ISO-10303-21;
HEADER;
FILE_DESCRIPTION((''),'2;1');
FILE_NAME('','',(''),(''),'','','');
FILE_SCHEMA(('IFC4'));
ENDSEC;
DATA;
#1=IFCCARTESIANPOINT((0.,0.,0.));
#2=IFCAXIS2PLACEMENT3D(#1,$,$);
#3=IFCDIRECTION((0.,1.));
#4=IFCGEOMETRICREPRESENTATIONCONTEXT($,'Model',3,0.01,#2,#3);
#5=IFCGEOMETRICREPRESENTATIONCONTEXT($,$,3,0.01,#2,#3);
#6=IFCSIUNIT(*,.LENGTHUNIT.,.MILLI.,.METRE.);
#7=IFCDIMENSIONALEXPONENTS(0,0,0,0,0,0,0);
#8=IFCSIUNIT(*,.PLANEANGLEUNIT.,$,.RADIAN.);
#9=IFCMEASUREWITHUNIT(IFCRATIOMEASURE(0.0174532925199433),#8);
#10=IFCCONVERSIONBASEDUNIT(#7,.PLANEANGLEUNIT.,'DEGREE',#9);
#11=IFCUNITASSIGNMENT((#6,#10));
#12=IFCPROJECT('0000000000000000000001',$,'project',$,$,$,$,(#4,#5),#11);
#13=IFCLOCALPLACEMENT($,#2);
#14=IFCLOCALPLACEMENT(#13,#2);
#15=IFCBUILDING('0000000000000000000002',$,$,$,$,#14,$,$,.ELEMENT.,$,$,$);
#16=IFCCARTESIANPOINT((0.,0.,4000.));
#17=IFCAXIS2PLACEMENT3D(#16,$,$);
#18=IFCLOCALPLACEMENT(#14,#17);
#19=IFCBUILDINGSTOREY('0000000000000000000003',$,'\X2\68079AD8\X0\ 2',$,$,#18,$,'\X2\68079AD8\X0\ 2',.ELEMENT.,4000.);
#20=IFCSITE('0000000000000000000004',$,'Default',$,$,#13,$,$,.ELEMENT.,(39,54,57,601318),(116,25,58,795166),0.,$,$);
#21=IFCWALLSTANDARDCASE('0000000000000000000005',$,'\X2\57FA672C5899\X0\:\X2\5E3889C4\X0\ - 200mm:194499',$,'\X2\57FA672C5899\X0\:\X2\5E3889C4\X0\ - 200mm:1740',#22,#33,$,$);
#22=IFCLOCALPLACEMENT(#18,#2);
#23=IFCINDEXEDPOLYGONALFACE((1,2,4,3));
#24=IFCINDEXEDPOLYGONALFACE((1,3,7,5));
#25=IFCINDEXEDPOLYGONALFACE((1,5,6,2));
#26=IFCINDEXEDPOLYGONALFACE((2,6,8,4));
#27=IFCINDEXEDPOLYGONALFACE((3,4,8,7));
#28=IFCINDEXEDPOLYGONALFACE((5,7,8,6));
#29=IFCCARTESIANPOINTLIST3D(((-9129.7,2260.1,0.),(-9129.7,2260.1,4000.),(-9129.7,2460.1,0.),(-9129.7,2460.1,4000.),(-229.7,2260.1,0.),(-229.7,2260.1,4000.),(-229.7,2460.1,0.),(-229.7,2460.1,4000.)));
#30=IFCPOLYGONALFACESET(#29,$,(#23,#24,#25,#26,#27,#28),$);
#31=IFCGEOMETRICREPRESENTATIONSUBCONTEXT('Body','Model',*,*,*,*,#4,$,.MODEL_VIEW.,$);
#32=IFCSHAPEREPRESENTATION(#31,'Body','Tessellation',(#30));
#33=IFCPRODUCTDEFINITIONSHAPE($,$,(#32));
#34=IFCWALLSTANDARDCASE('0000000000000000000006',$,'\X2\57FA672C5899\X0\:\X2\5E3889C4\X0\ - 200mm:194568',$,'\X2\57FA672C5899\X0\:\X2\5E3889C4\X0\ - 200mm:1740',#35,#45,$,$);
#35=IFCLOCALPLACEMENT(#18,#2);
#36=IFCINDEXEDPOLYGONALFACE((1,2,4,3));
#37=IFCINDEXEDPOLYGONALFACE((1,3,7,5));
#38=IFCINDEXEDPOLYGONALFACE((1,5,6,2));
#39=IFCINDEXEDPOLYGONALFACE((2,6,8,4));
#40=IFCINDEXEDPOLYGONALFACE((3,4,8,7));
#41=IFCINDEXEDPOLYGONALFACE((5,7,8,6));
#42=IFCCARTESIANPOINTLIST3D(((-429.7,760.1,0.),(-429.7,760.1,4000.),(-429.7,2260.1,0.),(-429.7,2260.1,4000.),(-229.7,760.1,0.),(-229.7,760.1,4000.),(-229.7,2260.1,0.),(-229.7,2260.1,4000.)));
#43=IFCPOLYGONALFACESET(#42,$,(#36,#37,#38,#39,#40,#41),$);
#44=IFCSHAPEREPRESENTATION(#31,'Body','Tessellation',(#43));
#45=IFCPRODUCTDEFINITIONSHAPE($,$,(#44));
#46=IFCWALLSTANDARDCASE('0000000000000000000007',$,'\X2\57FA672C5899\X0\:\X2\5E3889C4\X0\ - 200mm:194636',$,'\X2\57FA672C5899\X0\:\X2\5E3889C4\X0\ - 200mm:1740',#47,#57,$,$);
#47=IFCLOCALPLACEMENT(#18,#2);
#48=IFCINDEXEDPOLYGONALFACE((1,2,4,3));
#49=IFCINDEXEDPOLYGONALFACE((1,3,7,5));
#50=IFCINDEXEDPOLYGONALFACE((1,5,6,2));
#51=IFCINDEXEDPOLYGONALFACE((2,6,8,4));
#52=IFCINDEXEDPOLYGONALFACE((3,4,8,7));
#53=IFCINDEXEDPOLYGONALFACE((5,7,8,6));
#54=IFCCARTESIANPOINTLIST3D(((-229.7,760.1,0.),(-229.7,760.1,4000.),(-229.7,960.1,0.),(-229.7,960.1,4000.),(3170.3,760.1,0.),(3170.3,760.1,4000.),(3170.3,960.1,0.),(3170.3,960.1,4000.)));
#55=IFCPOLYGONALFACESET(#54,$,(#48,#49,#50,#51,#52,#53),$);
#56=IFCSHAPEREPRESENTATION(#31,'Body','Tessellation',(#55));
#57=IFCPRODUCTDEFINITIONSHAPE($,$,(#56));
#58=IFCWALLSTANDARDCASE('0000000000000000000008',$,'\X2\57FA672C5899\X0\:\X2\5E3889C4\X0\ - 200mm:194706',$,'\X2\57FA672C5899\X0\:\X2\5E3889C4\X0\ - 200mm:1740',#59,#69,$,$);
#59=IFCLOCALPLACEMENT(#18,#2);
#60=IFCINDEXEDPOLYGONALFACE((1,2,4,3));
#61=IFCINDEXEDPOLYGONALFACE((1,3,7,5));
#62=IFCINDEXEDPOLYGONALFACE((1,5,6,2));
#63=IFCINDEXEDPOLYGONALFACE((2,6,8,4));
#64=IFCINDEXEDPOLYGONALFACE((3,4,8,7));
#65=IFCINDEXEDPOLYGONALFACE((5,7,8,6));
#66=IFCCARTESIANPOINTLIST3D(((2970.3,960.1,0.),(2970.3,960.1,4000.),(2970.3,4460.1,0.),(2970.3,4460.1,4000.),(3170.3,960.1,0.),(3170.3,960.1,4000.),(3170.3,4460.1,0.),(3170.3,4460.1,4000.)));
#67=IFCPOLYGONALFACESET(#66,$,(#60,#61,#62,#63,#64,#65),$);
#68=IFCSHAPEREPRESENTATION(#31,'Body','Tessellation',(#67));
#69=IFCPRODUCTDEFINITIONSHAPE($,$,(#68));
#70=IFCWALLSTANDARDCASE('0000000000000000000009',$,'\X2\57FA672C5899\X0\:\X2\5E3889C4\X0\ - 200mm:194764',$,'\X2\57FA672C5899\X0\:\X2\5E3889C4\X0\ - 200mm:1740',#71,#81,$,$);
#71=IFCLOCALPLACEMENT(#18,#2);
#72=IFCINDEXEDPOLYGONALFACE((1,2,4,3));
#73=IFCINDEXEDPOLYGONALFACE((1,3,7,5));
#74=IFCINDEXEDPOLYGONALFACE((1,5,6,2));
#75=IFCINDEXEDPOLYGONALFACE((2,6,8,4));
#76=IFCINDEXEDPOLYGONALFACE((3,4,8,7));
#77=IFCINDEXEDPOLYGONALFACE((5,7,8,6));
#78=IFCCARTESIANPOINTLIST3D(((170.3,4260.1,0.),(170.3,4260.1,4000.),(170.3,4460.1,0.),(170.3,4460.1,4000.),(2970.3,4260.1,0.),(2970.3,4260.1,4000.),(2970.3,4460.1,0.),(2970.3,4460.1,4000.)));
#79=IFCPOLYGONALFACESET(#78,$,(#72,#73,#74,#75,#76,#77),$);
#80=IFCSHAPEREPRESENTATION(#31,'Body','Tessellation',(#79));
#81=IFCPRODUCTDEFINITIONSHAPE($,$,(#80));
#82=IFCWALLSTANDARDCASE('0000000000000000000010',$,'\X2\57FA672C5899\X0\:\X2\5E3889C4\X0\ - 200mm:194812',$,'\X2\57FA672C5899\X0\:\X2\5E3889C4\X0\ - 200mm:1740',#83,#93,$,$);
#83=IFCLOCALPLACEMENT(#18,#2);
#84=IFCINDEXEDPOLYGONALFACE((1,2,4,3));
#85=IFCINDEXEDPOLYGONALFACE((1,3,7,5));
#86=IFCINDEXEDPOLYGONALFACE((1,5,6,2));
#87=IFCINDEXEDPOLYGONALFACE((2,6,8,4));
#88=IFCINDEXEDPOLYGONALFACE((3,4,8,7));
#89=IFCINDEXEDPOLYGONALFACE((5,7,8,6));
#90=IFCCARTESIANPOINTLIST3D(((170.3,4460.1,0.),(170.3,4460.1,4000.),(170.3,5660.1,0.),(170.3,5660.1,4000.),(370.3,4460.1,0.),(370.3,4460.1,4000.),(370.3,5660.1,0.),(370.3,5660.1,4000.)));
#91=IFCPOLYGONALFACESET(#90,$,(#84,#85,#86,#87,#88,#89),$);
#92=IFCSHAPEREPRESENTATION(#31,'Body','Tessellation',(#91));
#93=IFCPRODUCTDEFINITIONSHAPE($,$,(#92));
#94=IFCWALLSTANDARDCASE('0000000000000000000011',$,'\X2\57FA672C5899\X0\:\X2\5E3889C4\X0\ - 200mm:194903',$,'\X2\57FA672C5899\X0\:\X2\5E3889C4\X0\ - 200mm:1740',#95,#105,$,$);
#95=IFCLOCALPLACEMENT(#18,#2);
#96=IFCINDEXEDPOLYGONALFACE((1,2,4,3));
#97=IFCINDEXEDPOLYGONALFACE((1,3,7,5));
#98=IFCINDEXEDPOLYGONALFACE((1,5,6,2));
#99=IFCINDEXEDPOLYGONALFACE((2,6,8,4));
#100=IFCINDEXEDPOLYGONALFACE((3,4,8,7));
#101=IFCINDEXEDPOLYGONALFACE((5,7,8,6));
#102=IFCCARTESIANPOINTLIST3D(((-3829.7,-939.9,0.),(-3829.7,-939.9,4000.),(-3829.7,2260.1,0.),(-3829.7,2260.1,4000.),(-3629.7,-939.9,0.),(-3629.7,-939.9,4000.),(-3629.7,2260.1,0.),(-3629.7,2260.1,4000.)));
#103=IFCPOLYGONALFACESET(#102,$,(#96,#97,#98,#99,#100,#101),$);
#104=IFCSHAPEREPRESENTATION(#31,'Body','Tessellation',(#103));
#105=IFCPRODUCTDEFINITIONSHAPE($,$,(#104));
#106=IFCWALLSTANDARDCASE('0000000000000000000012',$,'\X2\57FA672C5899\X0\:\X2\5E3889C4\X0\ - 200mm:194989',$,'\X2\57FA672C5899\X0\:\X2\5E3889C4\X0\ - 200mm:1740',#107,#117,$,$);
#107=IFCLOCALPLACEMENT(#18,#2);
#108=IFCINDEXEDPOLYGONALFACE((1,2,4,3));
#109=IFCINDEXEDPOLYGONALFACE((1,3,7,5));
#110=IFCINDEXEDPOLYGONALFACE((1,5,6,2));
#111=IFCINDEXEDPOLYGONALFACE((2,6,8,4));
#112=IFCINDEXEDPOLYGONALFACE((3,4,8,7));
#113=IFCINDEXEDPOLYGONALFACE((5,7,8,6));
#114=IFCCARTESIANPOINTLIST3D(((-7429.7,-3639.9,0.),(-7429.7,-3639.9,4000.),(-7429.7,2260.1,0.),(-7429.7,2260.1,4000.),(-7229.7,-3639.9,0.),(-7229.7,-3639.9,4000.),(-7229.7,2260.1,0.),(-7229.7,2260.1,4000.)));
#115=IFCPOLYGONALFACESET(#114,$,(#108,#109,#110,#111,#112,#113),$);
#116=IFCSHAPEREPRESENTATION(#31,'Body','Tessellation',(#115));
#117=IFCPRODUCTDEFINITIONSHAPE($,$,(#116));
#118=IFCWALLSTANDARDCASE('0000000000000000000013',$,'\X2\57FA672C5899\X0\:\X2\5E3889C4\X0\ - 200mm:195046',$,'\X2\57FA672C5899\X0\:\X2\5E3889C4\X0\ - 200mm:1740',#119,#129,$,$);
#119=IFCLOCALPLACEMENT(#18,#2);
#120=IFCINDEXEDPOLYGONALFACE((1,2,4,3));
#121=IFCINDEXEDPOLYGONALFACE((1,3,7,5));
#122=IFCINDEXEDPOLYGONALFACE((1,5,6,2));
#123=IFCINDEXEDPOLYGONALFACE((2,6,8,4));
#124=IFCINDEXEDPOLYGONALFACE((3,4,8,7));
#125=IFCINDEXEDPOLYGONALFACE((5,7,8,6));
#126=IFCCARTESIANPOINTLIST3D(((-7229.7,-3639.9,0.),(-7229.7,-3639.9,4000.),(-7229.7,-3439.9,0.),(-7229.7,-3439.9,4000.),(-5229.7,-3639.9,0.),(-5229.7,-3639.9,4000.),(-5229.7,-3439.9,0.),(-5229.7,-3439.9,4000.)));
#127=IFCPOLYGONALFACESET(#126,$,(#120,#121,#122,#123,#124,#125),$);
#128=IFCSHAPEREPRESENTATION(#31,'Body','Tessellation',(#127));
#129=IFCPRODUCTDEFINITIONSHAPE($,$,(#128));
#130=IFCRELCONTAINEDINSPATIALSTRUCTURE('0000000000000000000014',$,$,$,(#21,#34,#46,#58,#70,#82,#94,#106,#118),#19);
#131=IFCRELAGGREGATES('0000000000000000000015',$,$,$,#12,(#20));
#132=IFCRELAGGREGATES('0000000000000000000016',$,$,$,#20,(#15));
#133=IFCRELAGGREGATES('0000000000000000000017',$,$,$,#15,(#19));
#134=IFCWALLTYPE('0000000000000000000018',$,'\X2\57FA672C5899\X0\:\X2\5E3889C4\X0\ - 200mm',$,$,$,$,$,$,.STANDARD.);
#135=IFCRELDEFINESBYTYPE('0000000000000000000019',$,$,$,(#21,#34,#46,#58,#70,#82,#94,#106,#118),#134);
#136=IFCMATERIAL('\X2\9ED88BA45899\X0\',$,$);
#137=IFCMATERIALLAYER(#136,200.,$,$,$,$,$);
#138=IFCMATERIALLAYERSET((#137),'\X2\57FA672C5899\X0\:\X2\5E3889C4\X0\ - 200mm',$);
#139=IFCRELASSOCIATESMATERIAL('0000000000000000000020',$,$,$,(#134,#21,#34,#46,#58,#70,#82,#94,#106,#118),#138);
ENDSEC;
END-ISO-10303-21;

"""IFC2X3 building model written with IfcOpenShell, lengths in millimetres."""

from ifc_helpers import new_model, entity, si_unit, converted_unit, direction, frame, frame_2d, origin, place, context, subcontext, project, spatial, rectangle, extrude, material, layer, layer_set, layer_usage, type_object, element, save


model = new_model("IFC2X3")

# Units and contexts
model_context = context("Model", 3, precision=0.01, world=origin(), true_north=direction((0.0, 1.0)))
context_of_model = context(None, 3, precision=0.01, world=origin(), true_north=direction((0.0, 1.0)))
body_context = subcontext(model_context, "Body", "Model", "MODEL_VIEW")
ifc_project = project(units=[si_unit("LENGTHUNIT", "METRE", prefix="MILLI"), converted_unit("PLANEANGLEUNIT", "DEGREE", entity("IfcRatioMeasure", 0.0174532925199433), si_unit("PLANEANGLEUNIT", "RADIAN"), dimensions=[0, 0, 0, 0, 0, 0, 0])], contexts=[model_context, context_of_model])

# Site, building, storey
site_placement = place(None, origin())
site = spatial("IfcSite", under=ifc_project, at=site_placement, Name="Default", CompositionType="ELEMENT", RefLatitude=(39, 54, 57, 601318), RefLongitude=(116, 25, 58, 795166), RefElevation=0.0)
building_placement = place(site_placement, origin())
building = spatial("IfcBuilding", under=site, at=building_placement, CompositionType="ELEMENT")
storey_placement = place(building_placement, frame((0.0, 0.0, 4000.0)))
storey = spatial("IfcBuildingStorey", under=building, at=storey_placement, Name="标高 2", LongName="标高 2", CompositionType="ELEMENT", Elevation=4000.0)

# Walls
ifc_material = material(Name="默认墙")
ifc_layer = layer(ifc_material, 200.0)
ifc_layer_set = layer_set([ifc_layer], Name="基本墙:常规 - 200mm")
ifc_layer_usage_1 = layer_usage(ifc_layer_set, "AXIS2", "NEGATIVE", 100.0)
wall_type = type_object("IfcWallType", Name="基本墙:常规 - 200mm", PredefinedType="STANDARD", material=ifc_layer_set)
wall_1_placement = place(storey_placement, frame((-9129.7, 2360.1, 0.0)))
element("IfcWallStandardCase", 1, at=wall_1_placement, inside=storey, type_object=wall_type, material=ifc_layer_usage_1, Name="基本墙:常规 - 200mm:194499", ObjectType="基本墙:常规 - 200mm:1740", context=body_context, shape_type="SweptSolid", body=[
    extrude(rectangle(XDim=8900.0, YDim=200.0, at=frame_2d((4450.0, 0.0), x_axis=(-1.0, 0.0))), origin(), (0.0, 0.0, 1.0), 4000.0),
])
ifc_layer_usage_2 = layer_usage(ifc_layer_set, "AXIS2", "NEGATIVE", 100.0)
wall_2_placement = place(storey_placement, frame((-329.7, 2260.1, 0.0), z_axis=(0.0, 0.0, 1.0), x_axis=(0.0, -1.0, 0.0)))
element("IfcWallStandardCase", 2, at=wall_2_placement, inside=storey, type_object=wall_type, material=ifc_layer_usage_2, Name="基本墙:常规 - 200mm:194568", ObjectType="基本墙:常规 - 200mm:1740", context=body_context, shape_type="SweptSolid", body=[
    extrude(rectangle(XDim=1500.0, YDim=200.0, at=frame_2d((750.0, 0.0), x_axis=(-1.0, 0.0))), origin(), (0.0, 0.0, 1.0), 4000.0),
])
ifc_layer_usage_3 = layer_usage(ifc_layer_set, "AXIS2", "NEGATIVE", 100.0)
wall_3_placement = place(storey_placement, frame((-229.7, 860.1, 0.0)))
element("IfcWallStandardCase", 3, at=wall_3_placement, inside=storey, type_object=wall_type, material=ifc_layer_usage_3, Name="基本墙:常规 - 200mm:194636", ObjectType="基本墙:常规 - 200mm:1740", context=body_context, shape_type="SweptSolid", body=[
    extrude(rectangle(XDim=3400.0, YDim=200.0, at=frame_2d((1700.0, 0.0), x_axis=(-1.0, 0.0))), origin(), (0.0, 0.0, 1.0), 4000.0),
])
ifc_layer_usage_4 = layer_usage(ifc_layer_set, "AXIS2", "NEGATIVE", 100.0)
wall_4_placement = place(storey_placement, frame((3070.3, 960.1, 0.0), z_axis=(0.0, 0.0, 1.0), x_axis=(0.0, 1.0, 0.0)))
element("IfcWallStandardCase", 4, at=wall_4_placement, inside=storey, type_object=wall_type, material=ifc_layer_usage_4, Name="基本墙:常规 - 200mm:194706", ObjectType="基本墙:常规 - 200mm:1740", context=body_context, shape_type="SweptSolid", body=[
    extrude(rectangle(XDim=3500.0, YDim=200.0, at=frame_2d((1750.0, 0.0), x_axis=(-1.0, 0.0))), origin(), (0.0, 0.0, 1.0), 4000.0),
])
ifc_layer_usage_5 = layer_usage(ifc_layer_set, "AXIS2", "NEGATIVE", 100.0)
wall_5_placement = place(storey_placement, frame((2970.3, 4360.1, 0.0), z_axis=(0.0, 0.0, 1.0), x_axis=(-1.0, 0.0, 0.0)))
element("IfcWallStandardCase", 5, at=wall_5_placement, inside=storey, type_object=wall_type, material=ifc_layer_usage_5, Name="基本墙:常规 - 200mm:194764", ObjectType="基本墙:常规 - 200mm:1740", context=body_context, shape_type="SweptSolid", body=[
    extrude(rectangle(XDim=2800.0, YDim=200.0, at=frame_2d((1400.0, 0.0), x_axis=(-1.0, 0.0))), origin(), (0.0, 0.0, 1.0), 4000.0),
])
ifc_layer_usage_6 = layer_usage(ifc_layer_set, "AXIS2", "NEGATIVE", 100.0)
wall_6_placement = place(storey_placement, frame((270.3, 4460.1, 0.0), z_axis=(0.0, 0.0, 1.0), x_axis=(0.0, 1.0, 0.0)))
element("IfcWallStandardCase", 6, at=wall_6_placement, inside=storey, type_object=wall_type, material=ifc_layer_usage_6, Name="基本墙:常规 - 200mm:194812", ObjectType="基本墙:常规 - 200mm:1740", context=body_context, shape_type="SweptSolid", body=[
    extrude(rectangle(XDim=1200.0, YDim=200.0, at=frame_2d((600.0, 0.0), x_axis=(-1.0, 0.0))), origin(), (0.0, 0.0, 1.0), 4000.0),
])
ifc_layer_usage_7 = layer_usage(ifc_layer_set, "AXIS2", "NEGATIVE", 100.0)
wall_7_placement = place(storey_placement, frame((-3729.7, 2260.1, 0.0), z_axis=(0.0, 0.0, 1.0), x_axis=(0.0, -1.0, 0.0)))
element("IfcWallStandardCase", 7, at=wall_7_placement, inside=storey, type_object=wall_type, material=ifc_layer_usage_7, Name="基本墙:常规 - 200mm:194903", ObjectType="基本墙:常规 - 200mm:1740", context=body_context, shape_type="SweptSolid", body=[
    extrude(rectangle(XDim=3200.0, YDim=200.0, at=frame_2d((1600.0, 0.0), x_axis=(-1.0, 0.0))), origin(), (0.0, 0.0, 1.0), 4000.0),
])
ifc_layer_usage_8 = layer_usage(ifc_layer_set, "AXIS2", "NEGATIVE", 100.0)
wall_8_placement = place(storey_placement, frame((-7329.7, 2260.1, 0.0), z_axis=(0.0, 0.0, 1.0), x_axis=(0.0, -1.0, 0.0)))
element("IfcWallStandardCase", 8, at=wall_8_placement, inside=storey, type_object=wall_type, material=ifc_layer_usage_8, Name="基本墙:常规 - 200mm:194989", ObjectType="基本墙:常规 - 200mm:1740", context=body_context, shape_type="SweptSolid", body=[
    extrude(rectangle(XDim=5900.0, YDim=200.0, at=frame_2d((2950.0, 0.0), x_axis=(-1.0, 0.0))), origin(), (0.0, 0.0, 1.0), 4000.0),
])
ifc_layer_usage_9 = layer_usage(ifc_layer_set, "AXIS2", "NEGATIVE", 100.0)
wall_9_placement = place(storey_placement, frame((-7229.7, -3539.9, 0.0)))
element("IfcWallStandardCase", 9, at=wall_9_placement, inside=storey, type_object=wall_type, material=ifc_layer_usage_9, Name="基本墙:常规 - 200mm:195046", ObjectType="基本墙:常规 - 200mm:1740", context=body_context, shape_type="SweptSolid", body=[
    extrude(rectangle(XDim=2000.0, YDim=200.0, at=frame_2d((1000.0, 0.0), x_axis=(-1.0, 0.0))), origin(), (0.0, 0.0, 1.0), 4000.0),
])

save(model, "model.ifc")
